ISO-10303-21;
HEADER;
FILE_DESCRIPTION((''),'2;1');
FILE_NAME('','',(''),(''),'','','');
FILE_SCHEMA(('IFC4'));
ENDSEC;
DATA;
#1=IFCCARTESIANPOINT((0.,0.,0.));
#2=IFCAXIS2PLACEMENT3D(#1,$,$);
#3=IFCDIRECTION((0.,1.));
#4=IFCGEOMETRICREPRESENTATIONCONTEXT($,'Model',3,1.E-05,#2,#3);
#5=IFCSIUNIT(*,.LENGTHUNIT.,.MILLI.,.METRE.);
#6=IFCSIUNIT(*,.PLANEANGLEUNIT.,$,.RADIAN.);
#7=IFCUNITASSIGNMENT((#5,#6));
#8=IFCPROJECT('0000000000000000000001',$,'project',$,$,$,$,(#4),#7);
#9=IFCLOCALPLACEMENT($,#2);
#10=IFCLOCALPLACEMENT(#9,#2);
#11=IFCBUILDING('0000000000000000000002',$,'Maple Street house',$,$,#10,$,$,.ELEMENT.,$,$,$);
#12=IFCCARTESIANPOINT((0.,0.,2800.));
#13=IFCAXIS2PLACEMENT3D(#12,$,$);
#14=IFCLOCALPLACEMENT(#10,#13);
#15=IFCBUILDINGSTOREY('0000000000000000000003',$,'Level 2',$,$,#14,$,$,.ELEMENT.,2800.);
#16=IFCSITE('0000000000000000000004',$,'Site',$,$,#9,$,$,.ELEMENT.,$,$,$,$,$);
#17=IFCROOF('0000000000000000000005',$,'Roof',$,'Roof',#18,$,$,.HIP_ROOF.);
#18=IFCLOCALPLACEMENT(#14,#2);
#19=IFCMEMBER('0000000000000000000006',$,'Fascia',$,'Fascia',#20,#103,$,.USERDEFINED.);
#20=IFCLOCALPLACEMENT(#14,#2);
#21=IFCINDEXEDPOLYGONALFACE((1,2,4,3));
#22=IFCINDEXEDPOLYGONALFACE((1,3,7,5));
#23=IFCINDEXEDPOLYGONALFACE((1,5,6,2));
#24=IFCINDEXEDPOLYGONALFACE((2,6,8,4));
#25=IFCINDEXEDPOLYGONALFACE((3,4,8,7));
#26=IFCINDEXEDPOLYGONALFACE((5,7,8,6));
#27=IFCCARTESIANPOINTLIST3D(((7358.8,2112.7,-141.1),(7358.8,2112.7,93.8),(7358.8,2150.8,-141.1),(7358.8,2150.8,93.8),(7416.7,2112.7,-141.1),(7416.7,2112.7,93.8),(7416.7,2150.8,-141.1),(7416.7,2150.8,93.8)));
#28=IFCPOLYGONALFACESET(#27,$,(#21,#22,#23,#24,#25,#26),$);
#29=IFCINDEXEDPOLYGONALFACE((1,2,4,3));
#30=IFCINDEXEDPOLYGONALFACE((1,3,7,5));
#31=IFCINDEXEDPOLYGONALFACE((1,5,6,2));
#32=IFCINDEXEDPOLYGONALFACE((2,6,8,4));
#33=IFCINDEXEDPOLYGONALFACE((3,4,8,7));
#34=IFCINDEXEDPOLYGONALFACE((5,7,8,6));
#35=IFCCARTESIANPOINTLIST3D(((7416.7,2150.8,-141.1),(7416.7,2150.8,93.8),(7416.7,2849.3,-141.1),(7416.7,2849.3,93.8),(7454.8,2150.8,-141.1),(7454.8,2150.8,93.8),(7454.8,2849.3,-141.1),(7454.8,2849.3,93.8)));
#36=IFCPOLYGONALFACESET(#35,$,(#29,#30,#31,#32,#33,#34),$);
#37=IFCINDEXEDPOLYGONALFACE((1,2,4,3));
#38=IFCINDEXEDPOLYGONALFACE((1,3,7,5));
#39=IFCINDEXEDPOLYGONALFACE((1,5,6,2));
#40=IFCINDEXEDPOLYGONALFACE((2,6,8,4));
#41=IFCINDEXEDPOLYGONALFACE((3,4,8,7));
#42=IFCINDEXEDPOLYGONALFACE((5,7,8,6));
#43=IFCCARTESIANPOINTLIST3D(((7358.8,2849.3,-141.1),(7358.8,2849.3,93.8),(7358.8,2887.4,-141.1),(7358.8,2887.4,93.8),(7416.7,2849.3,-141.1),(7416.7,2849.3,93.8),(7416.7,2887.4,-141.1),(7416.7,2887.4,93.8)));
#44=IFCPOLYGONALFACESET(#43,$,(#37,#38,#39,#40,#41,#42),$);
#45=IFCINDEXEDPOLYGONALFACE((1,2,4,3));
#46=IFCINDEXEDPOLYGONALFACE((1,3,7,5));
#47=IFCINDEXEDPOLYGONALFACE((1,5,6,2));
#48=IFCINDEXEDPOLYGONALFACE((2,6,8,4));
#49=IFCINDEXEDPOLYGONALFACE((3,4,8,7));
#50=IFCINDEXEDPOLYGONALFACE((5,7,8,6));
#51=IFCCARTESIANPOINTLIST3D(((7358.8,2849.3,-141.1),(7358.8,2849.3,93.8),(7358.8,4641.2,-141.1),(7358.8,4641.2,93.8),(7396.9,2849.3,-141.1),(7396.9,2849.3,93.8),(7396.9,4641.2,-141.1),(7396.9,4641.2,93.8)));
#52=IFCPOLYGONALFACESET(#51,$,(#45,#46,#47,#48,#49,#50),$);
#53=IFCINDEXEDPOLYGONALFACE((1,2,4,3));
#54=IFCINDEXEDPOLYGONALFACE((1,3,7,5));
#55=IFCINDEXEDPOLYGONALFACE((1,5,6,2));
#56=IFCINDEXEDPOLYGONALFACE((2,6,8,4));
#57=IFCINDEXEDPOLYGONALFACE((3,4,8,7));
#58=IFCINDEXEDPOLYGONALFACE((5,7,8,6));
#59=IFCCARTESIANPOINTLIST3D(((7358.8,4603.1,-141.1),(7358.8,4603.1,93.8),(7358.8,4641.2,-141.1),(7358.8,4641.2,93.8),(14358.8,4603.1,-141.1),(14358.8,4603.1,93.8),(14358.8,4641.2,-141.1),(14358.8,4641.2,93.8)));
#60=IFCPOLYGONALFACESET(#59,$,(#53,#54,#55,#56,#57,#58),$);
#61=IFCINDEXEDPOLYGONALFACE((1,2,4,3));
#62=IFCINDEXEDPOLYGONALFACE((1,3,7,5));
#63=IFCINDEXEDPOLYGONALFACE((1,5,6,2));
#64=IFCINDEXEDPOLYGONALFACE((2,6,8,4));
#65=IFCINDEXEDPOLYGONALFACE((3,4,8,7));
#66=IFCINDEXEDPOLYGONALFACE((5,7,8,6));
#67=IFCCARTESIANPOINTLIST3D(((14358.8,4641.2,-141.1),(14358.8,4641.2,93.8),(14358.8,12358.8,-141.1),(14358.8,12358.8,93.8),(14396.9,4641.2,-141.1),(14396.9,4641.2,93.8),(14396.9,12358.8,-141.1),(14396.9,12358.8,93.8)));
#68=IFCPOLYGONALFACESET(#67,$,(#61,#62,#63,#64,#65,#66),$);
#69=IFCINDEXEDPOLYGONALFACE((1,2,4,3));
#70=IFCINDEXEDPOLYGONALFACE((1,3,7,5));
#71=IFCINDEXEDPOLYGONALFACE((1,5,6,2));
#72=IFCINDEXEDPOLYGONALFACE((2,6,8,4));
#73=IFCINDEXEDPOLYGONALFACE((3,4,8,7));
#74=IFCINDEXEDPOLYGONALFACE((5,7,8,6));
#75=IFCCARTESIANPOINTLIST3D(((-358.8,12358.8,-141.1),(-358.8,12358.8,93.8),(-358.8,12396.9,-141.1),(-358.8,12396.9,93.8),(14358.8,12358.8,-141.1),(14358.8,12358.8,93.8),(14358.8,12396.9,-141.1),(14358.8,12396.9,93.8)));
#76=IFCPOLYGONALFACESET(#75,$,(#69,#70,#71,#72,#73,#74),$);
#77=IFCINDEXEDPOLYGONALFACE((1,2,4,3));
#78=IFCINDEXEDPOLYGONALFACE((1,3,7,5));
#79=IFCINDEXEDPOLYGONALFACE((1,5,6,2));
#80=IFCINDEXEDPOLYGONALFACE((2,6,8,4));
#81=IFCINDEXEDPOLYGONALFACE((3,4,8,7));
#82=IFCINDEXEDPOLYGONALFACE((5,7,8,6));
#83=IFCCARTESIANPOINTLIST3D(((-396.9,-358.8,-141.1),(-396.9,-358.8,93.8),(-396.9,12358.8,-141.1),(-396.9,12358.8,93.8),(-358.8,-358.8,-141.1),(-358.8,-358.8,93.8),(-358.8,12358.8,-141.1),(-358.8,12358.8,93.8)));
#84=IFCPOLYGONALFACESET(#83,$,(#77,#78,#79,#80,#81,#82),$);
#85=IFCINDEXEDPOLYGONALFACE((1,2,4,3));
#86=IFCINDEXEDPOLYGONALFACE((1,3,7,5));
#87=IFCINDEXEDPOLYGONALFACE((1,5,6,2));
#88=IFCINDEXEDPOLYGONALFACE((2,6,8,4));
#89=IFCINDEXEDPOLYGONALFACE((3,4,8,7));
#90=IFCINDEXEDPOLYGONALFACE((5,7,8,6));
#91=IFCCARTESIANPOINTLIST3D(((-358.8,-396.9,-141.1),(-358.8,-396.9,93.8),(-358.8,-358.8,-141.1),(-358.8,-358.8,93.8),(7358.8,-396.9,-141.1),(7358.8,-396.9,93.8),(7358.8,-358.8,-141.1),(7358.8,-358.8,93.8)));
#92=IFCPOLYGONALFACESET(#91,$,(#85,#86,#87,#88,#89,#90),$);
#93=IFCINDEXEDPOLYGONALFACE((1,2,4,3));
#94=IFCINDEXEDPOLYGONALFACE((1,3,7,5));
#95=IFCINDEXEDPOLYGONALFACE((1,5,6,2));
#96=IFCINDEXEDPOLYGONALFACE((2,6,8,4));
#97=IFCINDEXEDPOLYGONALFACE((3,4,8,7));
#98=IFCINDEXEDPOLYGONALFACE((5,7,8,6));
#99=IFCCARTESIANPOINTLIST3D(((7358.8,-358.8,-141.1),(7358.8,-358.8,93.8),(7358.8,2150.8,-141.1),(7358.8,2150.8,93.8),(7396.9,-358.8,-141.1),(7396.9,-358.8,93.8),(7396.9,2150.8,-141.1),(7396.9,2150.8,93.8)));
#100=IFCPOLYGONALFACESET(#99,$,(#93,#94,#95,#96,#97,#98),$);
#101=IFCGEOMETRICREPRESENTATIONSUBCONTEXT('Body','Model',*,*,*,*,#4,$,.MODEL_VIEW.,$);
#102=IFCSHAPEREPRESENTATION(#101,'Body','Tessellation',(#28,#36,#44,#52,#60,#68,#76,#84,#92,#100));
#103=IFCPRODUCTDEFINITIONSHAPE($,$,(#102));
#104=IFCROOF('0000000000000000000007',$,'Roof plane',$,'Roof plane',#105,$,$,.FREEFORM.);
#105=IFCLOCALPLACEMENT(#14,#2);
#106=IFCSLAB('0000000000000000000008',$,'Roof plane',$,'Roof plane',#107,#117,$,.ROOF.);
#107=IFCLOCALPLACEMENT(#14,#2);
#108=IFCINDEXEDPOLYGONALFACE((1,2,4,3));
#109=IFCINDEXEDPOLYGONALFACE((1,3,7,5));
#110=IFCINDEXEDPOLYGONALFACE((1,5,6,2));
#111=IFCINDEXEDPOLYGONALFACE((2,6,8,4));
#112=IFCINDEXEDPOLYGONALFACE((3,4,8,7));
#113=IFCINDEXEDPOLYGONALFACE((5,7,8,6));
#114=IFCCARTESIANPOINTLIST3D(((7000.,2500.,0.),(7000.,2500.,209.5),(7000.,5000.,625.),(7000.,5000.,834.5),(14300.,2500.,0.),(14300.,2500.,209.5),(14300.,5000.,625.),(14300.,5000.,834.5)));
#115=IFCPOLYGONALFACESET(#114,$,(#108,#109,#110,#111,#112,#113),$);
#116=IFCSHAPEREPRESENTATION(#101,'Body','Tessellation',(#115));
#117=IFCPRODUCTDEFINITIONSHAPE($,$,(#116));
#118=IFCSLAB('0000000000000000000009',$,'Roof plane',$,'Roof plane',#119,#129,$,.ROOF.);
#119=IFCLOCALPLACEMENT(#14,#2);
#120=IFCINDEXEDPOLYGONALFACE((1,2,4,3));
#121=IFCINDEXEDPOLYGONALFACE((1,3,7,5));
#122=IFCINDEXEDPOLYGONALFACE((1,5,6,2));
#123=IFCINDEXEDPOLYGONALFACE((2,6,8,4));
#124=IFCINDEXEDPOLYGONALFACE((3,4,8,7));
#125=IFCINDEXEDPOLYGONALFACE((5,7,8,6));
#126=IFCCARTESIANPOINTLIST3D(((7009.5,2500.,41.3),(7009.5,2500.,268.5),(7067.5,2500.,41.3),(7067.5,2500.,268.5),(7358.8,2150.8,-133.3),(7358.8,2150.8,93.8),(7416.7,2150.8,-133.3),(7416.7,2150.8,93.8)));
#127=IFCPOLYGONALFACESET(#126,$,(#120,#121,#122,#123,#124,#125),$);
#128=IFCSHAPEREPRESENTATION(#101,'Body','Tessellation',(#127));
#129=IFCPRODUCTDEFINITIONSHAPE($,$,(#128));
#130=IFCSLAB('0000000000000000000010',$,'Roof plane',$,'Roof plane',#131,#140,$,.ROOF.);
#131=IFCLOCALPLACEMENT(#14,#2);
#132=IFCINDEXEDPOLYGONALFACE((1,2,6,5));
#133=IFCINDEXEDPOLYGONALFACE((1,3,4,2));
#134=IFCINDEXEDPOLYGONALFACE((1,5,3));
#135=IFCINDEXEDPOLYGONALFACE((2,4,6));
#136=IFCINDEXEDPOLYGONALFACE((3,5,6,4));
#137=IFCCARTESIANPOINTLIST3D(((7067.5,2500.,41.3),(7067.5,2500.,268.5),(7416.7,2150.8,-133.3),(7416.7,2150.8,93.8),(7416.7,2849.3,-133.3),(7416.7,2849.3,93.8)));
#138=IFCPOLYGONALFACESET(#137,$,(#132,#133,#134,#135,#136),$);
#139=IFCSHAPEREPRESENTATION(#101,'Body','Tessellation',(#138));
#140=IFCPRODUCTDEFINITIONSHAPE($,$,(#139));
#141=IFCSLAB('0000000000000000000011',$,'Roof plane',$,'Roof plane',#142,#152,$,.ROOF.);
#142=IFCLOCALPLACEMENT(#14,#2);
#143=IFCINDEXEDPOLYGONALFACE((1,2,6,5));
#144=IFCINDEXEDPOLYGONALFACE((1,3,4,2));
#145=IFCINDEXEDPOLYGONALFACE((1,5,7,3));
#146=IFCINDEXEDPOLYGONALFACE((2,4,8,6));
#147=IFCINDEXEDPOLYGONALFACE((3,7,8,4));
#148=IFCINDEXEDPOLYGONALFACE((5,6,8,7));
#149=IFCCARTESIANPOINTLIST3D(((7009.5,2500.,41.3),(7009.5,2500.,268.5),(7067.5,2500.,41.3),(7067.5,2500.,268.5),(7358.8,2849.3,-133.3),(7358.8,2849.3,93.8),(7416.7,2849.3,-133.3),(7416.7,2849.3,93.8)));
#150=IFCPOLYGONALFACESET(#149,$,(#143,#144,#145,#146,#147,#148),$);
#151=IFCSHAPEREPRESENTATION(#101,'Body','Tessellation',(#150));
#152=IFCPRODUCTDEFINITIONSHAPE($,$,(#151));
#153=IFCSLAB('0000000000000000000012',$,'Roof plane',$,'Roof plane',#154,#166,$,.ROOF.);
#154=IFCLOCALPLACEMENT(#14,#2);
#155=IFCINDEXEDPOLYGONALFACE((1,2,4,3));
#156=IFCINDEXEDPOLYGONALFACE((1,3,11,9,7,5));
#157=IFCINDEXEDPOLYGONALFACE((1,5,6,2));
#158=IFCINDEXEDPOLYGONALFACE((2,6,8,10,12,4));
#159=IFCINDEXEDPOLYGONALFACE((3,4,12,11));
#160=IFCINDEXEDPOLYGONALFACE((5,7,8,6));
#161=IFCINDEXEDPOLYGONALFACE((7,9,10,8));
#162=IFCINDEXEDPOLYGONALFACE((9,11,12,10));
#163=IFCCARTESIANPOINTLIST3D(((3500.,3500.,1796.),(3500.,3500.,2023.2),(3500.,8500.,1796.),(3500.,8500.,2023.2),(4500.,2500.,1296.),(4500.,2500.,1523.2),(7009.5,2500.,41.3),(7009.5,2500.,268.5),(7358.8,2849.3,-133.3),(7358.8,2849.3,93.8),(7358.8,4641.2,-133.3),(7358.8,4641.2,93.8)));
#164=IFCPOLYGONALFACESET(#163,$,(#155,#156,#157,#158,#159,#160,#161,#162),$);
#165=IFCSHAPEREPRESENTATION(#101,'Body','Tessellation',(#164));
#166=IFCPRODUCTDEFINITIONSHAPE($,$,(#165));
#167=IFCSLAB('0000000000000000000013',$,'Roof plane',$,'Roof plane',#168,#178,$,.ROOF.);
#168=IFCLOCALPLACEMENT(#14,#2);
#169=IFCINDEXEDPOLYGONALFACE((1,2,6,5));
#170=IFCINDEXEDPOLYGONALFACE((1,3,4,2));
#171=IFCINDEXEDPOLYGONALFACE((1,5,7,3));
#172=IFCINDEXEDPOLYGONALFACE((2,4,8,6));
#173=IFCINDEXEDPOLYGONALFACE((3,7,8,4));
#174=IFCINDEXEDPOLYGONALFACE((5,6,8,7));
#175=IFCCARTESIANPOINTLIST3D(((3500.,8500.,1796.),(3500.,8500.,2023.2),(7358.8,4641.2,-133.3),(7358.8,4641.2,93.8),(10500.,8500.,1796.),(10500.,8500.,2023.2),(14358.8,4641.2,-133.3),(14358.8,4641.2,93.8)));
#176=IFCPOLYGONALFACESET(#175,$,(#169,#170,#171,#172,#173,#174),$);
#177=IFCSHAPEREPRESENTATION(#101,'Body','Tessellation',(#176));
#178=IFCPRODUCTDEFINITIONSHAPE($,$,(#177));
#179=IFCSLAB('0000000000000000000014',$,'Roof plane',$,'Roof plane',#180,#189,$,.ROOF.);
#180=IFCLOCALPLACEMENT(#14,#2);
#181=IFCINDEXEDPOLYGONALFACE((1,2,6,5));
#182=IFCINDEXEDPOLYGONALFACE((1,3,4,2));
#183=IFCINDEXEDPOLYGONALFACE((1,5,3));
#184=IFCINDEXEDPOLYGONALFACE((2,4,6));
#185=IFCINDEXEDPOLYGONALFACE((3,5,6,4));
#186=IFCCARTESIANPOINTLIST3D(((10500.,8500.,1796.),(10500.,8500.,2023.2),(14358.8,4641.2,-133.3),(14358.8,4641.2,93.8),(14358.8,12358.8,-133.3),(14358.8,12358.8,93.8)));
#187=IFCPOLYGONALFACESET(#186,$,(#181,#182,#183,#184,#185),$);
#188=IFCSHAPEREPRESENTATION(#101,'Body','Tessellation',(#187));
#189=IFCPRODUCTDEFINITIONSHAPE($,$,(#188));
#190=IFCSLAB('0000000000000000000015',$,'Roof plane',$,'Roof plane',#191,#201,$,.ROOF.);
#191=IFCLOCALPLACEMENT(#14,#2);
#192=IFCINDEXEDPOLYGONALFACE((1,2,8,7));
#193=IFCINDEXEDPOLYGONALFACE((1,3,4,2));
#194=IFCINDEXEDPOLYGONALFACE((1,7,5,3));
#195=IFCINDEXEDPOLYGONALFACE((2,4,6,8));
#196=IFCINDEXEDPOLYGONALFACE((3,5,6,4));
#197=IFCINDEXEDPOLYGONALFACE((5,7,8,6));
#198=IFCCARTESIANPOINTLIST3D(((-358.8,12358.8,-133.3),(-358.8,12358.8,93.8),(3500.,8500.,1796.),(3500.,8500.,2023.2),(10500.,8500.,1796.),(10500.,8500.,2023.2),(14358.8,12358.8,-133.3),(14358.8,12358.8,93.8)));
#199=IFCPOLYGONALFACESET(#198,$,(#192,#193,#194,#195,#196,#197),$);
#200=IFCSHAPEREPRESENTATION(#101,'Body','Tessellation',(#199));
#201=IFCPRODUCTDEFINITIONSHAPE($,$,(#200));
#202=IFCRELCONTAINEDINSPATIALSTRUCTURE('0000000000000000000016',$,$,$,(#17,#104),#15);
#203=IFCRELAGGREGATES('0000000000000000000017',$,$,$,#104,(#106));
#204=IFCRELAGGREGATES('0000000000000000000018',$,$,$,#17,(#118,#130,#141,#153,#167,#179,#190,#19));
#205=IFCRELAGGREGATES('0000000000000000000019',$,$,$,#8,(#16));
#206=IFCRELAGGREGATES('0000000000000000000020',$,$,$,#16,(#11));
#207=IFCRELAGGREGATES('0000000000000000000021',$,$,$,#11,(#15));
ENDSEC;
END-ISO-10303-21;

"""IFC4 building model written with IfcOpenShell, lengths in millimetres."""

from ifc_helpers import new_model, si_unit, direction, frame, origin, origin_with_axes, place, context, subcontext, project, spatial, polyline, outline, extrude, element, aggregate, save


model = new_model("IFC4")

# Units and contexts
model_context = context("Model", 3, precision=1e-05, world=origin(), true_north=direction((0.0, 1.0)))
body_context = subcontext(model_context, "Body", "Model", "MODEL_VIEW")
ifc_project = project(units=[si_unit("LENGTHUNIT", "METRE", prefix="MILLI"), si_unit("PLANEANGLEUNIT", "RADIAN")], contexts=[model_context])

# Site, building, storey
site_placement = place(None, origin())
site = spatial("IfcSite", under=ifc_project, at=site_placement, Name="Site", CompositionType="ELEMENT")
building_placement = place(site_placement, origin())
building = spatial("IfcBuilding", under=site, at=building_placement, Name="Maple Street house", CompositionType="ELEMENT")
storey_placement = place(building_placement, frame((0.0, 0.0, 2800.0)))
storey = spatial("IfcBuildingStorey", under=building, at=storey_placement, Name="Level 2", CompositionType="ELEMENT", Elevation=2800.0)

# Roof, member
roof_1_placement = place(storey_placement, origin_with_axes())
roof_1 = element("IfcRoof", 1, at=roof_1_placement, inside=storey, Name="Roof", ObjectType="Roof", PredefinedType="HIP_ROOF")
member_placement = place(storey_placement, origin_with_axes())
member = element("IfcMember", 2, at=member_placement, Name="Fascia", ObjectType="Fascia", PredefinedType="USERDEFINED", context=body_context, shape_type="SweptSolid", body=[
    extrude(outline(polyline([(0.0, -234.9), (57.9, -234.9), (57.9, 0.0), (0.0, 0.0), (0.0, -234.9)])), frame((7358.8, 2150.8, 93.8), z_axis=(0.0, -1.0, 0.0), x_axis=(1.0, 0.0, 0.0)), (0.0, 0.0, 1.0), 38.1),
    extrude(outline(polyline([(0.0, -234.9), (698.5, -234.9), (698.5, 0.0), (0.0, 0.0), (0.0, -234.9)])), frame((7416.7, 2150.8, 93.8), z_axis=(1.0, 0.0, 0.0), x_axis=(0.0, 1.0, 0.0)), (0.0, 0.0, 1.0), 38.1),
    extrude(outline(polyline([(0.0, -234.9), (57.9, -234.9), (57.9, 0.0), (0.0, 0.0), (0.0, -234.9)])), frame((7416.7, 2849.3, 93.8), z_axis=(0.0, 1.0, 0.0), x_axis=(-1.0, 0.0, 0.0)), (0.0, 0.0, 1.0), 38.1),
    extrude(outline(polyline([(0.0, -234.9), (1792.0, -234.9), (1792.0, 0.0), (0.0, 0.0), (0.0, -234.9)])), frame((7358.8, 2849.3, 93.8), z_axis=(1.0, 0.0, 0.0), x_axis=(0.0, 1.0, 0.0)), (0.0, 0.0, 1.0), 38.1),
    extrude(outline(polyline([(0.0, -234.9), (7000.0, -234.9), (7000.0, 0.0), (0.0, 0.0), (0.0, -234.9)])), frame((7358.8, 4641.2, 93.8), z_axis=(0.0, -1.0, 0.0), x_axis=(1.0, 0.0, 0.0)), (0.0, 0.0, 1.0), 38.1),
    extrude(outline(polyline([(0.0, -234.9), (7717.6, -234.9), (7717.6, 0.0), (0.0, 0.0), (0.0, -234.9)])), frame((14358.8, 4641.2, 93.8), z_axis=(1.0, 0.0, 0.0), x_axis=(0.0, 1.0, 0.0)), (0.0, 0.0, 1.0), 38.1),
    extrude(outline(polyline([(0.0, -234.9), (14717.5, -234.9), (14717.5, 0.0), (0.0, 0.0), (0.0, -234.9)])), frame((14358.8, 12358.8, 93.8), z_axis=(0.0, 1.0, 0.0), x_axis=(-1.0, 0.0, 0.0)), (0.0, 0.0, 1.0), 38.1),
    extrude(outline(polyline([(0.0, -234.9), (12717.5, -234.9), (12717.5, 0.0), (0.0, 0.0), (0.0, -234.9)])), frame((-358.8, 12358.8, 93.8), z_axis=(-1.0, 0.0, 0.0), x_axis=(0.0, -1.0, 0.0)), (0.0, 0.0, 1.0), 38.1),
    extrude(outline(polyline([(0.0, -234.9), (7717.6, -234.9), (7717.6, 0.0), (0.0, 0.0), (0.0, -234.9)])), frame((-358.8, -358.8, 93.8), z_axis=(0.0, -1.0, 0.0), x_axis=(1.0, 0.0, 0.0)), (0.0, 0.0, 1.0), 38.1),
    extrude(outline(polyline([(0.0, -234.9), (2509.5, -234.9), (2509.5, 0.0), (0.0, 0.0), (0.0, -234.9)])), frame((7358.8, -358.8, 93.8), z_axis=(1.0, 0.0, 0.0), x_axis=(0.0, 1.0, 0.0)), (0.0, 0.0, 1.0), 38.1),
])

# Roof, slab
roof_2_placement = place(storey_placement, origin_with_axes())
roof_2 = element("IfcRoof", 3, at=roof_2_placement, inside=storey, Name="Roof plane", ObjectType="Roof plane", PredefinedType="FREEFORM")
slab_1_placement = place(storey_placement, origin_with_axes())
slab_1 = element("IfcSlab", 4, at=slab_1_placement, Name="Roof plane", ObjectType="Roof plane", PredefinedType="ROOF", context=body_context, shape_type="SweptSolid", body=[
    extrude(outline(polyline([(0.0, 0.0), (7300.0, 0.0), (7300.0, 2576.9), (0.0, 2576.9), (0.0, 0.0)])), frame((7000.0, 2500.0, 0.0), z_axis=(0.0, -0.242536, 0.970143), x_axis=(1.0, 0.0, 0.0)), (0.0, 0.242536, 0.970143), 209.5),
])
aggregate(roof_2, [slab_1])

# Slabs
slab_2_placement = place(storey_placement, origin_with_axes())
slab_2 = element("IfcSlab", 5, at=slab_2_placement, Name="Roof plane", ObjectType="Roof plane", PredefinedType="ROOF", context=body_context, shape_type="SweptSolid", body=[
    extrude(outline(polyline([(7358.8, 0.0), (7416.7, 0.0), (7067.5, 390.5), (7009.5, 390.5), (7358.8, 0.0)])), frame((0.0, 2150.8, -133.3), z_axis=(0.0, -0.447214, 0.894427), x_axis=(1.0, 0.0, 0.0)), (0.0, 0.447214, 0.894427), 227.2),
])
slab_3_placement = place(storey_placement, origin_with_axes())
slab_3 = element("IfcSlab", 6, at=slab_3_placement, Name="Roof plane", ObjectType="Roof plane", PredefinedType="ROOF", context=body_context, shape_type="SweptSolid", body=[
    extrude(outline(polyline([(2150.8, 0.0), (2849.3, 0.0), (2500.0, 390.5), (2150.8, 0.0)])), frame((7416.7, 0.0, -133.3), z_axis=(0.447214, 0.0, 0.894427), x_axis=(0.0, 1.0, 0.0)), (0.0, 0.447214, 0.894427), 227.2),
])
slab_4_placement = place(storey_placement, origin_with_axes())
slab_4 = element("IfcSlab", 7, at=slab_4_placement, Name="Roof plane", ObjectType="Roof plane", PredefinedType="ROOF", context=body_context, shape_type="SweptSolid", body=[
    extrude(outline(polyline([(-7416.7, 0.0), (-7358.8, 0.0), (-7009.5, 390.5), (-7067.5, 390.5), (-7416.7, 0.0)])), frame((0.0, 2849.3, -133.3), z_axis=(0.0, 0.447214, 0.894427), x_axis=(-1.0, 0.0, 0.0)), (0.0, 0.447214, 0.894427), 227.2),
])
slab_5_placement = place(storey_placement, origin_with_axes())
slab_5 = element("IfcSlab", 8, at=slab_5_placement, Name="Roof plane", ObjectType="Roof plane", PredefinedType="ROOF", context=body_context, shape_type="SweptSolid", body=[
    extrude(outline(polyline([(2849.3, 0.0), (4641.2, 0.0), (8500.0, 4314.2), (3500.0, 4314.2), (2500.0, 3196.2), (2500.0, 390.5), (2849.3, 0.0)])), frame((7358.8, 0.0, -133.3), z_axis=(0.447214, 0.0, 0.894427), x_axis=(0.0, 1.0, 0.0)), (0.0, 0.447214, 0.894427), 227.2),
])
slab_6_placement = place(storey_placement, origin_with_axes())
slab_6 = element("IfcSlab", 9, at=slab_6_placement, Name="Roof plane", ObjectType="Roof plane", PredefinedType="ROOF", context=body_context, shape_type="SweptSolid", body=[
    extrude(outline(polyline([(7358.8, 0.0), (14358.8, 0.0), (10500.0, 4314.2), (3500.0, 4314.2), (7358.8, 0.0)])), frame((0.0, 4641.2, -133.3), z_axis=(0.0, -0.447214, 0.894427), x_axis=(1.0, 0.0, 0.0)), (0.0, 0.447214, 0.894427), 227.2),
])
slab_7_placement = place(storey_placement, origin_with_axes())
slab_7 = element("IfcSlab", 10, at=slab_7_placement, Name="Roof plane", ObjectType="Roof plane", PredefinedType="ROOF", context=body_context, shape_type="SweptSolid", body=[
    extrude(outline(polyline([(4641.2, 0.0), (12358.8, 0.0), (8500.0, 4314.2), (4641.2, 0.0)])), frame((14358.8, 0.0, -133.3), z_axis=(0.447214, 0.0, 0.894427), x_axis=(0.0, 1.0, 0.0)), (0.0, 0.447214, 0.894427), 227.2),
])
slab_8_placement = place(storey_placement, origin_with_axes())
slab_8 = element("IfcSlab", 11, at=slab_8_placement, Name="Roof plane", ObjectType="Roof plane", PredefinedType="ROOF", context=body_context, shape_type="SweptSolid", body=[
    extrude(outline(polyline([(-14358.8, 0.0), (358.8, 0.0), (-3500.0, 4314.2), (-10500.0, 4314.2), (-14358.8, 0.0)])), frame((0.0, 12358.8, -133.3), z_axis=(0.0, 0.447214, 0.894427), x_axis=(-1.0, 0.0, 0.0)), (0.0, 0.447214, 0.894427), 227.2),
])

aggregate(roof_1, [slab_2, slab_3, slab_4, slab_5, slab_6, slab_7, slab_8, member])

save(model, "model.ifc")
